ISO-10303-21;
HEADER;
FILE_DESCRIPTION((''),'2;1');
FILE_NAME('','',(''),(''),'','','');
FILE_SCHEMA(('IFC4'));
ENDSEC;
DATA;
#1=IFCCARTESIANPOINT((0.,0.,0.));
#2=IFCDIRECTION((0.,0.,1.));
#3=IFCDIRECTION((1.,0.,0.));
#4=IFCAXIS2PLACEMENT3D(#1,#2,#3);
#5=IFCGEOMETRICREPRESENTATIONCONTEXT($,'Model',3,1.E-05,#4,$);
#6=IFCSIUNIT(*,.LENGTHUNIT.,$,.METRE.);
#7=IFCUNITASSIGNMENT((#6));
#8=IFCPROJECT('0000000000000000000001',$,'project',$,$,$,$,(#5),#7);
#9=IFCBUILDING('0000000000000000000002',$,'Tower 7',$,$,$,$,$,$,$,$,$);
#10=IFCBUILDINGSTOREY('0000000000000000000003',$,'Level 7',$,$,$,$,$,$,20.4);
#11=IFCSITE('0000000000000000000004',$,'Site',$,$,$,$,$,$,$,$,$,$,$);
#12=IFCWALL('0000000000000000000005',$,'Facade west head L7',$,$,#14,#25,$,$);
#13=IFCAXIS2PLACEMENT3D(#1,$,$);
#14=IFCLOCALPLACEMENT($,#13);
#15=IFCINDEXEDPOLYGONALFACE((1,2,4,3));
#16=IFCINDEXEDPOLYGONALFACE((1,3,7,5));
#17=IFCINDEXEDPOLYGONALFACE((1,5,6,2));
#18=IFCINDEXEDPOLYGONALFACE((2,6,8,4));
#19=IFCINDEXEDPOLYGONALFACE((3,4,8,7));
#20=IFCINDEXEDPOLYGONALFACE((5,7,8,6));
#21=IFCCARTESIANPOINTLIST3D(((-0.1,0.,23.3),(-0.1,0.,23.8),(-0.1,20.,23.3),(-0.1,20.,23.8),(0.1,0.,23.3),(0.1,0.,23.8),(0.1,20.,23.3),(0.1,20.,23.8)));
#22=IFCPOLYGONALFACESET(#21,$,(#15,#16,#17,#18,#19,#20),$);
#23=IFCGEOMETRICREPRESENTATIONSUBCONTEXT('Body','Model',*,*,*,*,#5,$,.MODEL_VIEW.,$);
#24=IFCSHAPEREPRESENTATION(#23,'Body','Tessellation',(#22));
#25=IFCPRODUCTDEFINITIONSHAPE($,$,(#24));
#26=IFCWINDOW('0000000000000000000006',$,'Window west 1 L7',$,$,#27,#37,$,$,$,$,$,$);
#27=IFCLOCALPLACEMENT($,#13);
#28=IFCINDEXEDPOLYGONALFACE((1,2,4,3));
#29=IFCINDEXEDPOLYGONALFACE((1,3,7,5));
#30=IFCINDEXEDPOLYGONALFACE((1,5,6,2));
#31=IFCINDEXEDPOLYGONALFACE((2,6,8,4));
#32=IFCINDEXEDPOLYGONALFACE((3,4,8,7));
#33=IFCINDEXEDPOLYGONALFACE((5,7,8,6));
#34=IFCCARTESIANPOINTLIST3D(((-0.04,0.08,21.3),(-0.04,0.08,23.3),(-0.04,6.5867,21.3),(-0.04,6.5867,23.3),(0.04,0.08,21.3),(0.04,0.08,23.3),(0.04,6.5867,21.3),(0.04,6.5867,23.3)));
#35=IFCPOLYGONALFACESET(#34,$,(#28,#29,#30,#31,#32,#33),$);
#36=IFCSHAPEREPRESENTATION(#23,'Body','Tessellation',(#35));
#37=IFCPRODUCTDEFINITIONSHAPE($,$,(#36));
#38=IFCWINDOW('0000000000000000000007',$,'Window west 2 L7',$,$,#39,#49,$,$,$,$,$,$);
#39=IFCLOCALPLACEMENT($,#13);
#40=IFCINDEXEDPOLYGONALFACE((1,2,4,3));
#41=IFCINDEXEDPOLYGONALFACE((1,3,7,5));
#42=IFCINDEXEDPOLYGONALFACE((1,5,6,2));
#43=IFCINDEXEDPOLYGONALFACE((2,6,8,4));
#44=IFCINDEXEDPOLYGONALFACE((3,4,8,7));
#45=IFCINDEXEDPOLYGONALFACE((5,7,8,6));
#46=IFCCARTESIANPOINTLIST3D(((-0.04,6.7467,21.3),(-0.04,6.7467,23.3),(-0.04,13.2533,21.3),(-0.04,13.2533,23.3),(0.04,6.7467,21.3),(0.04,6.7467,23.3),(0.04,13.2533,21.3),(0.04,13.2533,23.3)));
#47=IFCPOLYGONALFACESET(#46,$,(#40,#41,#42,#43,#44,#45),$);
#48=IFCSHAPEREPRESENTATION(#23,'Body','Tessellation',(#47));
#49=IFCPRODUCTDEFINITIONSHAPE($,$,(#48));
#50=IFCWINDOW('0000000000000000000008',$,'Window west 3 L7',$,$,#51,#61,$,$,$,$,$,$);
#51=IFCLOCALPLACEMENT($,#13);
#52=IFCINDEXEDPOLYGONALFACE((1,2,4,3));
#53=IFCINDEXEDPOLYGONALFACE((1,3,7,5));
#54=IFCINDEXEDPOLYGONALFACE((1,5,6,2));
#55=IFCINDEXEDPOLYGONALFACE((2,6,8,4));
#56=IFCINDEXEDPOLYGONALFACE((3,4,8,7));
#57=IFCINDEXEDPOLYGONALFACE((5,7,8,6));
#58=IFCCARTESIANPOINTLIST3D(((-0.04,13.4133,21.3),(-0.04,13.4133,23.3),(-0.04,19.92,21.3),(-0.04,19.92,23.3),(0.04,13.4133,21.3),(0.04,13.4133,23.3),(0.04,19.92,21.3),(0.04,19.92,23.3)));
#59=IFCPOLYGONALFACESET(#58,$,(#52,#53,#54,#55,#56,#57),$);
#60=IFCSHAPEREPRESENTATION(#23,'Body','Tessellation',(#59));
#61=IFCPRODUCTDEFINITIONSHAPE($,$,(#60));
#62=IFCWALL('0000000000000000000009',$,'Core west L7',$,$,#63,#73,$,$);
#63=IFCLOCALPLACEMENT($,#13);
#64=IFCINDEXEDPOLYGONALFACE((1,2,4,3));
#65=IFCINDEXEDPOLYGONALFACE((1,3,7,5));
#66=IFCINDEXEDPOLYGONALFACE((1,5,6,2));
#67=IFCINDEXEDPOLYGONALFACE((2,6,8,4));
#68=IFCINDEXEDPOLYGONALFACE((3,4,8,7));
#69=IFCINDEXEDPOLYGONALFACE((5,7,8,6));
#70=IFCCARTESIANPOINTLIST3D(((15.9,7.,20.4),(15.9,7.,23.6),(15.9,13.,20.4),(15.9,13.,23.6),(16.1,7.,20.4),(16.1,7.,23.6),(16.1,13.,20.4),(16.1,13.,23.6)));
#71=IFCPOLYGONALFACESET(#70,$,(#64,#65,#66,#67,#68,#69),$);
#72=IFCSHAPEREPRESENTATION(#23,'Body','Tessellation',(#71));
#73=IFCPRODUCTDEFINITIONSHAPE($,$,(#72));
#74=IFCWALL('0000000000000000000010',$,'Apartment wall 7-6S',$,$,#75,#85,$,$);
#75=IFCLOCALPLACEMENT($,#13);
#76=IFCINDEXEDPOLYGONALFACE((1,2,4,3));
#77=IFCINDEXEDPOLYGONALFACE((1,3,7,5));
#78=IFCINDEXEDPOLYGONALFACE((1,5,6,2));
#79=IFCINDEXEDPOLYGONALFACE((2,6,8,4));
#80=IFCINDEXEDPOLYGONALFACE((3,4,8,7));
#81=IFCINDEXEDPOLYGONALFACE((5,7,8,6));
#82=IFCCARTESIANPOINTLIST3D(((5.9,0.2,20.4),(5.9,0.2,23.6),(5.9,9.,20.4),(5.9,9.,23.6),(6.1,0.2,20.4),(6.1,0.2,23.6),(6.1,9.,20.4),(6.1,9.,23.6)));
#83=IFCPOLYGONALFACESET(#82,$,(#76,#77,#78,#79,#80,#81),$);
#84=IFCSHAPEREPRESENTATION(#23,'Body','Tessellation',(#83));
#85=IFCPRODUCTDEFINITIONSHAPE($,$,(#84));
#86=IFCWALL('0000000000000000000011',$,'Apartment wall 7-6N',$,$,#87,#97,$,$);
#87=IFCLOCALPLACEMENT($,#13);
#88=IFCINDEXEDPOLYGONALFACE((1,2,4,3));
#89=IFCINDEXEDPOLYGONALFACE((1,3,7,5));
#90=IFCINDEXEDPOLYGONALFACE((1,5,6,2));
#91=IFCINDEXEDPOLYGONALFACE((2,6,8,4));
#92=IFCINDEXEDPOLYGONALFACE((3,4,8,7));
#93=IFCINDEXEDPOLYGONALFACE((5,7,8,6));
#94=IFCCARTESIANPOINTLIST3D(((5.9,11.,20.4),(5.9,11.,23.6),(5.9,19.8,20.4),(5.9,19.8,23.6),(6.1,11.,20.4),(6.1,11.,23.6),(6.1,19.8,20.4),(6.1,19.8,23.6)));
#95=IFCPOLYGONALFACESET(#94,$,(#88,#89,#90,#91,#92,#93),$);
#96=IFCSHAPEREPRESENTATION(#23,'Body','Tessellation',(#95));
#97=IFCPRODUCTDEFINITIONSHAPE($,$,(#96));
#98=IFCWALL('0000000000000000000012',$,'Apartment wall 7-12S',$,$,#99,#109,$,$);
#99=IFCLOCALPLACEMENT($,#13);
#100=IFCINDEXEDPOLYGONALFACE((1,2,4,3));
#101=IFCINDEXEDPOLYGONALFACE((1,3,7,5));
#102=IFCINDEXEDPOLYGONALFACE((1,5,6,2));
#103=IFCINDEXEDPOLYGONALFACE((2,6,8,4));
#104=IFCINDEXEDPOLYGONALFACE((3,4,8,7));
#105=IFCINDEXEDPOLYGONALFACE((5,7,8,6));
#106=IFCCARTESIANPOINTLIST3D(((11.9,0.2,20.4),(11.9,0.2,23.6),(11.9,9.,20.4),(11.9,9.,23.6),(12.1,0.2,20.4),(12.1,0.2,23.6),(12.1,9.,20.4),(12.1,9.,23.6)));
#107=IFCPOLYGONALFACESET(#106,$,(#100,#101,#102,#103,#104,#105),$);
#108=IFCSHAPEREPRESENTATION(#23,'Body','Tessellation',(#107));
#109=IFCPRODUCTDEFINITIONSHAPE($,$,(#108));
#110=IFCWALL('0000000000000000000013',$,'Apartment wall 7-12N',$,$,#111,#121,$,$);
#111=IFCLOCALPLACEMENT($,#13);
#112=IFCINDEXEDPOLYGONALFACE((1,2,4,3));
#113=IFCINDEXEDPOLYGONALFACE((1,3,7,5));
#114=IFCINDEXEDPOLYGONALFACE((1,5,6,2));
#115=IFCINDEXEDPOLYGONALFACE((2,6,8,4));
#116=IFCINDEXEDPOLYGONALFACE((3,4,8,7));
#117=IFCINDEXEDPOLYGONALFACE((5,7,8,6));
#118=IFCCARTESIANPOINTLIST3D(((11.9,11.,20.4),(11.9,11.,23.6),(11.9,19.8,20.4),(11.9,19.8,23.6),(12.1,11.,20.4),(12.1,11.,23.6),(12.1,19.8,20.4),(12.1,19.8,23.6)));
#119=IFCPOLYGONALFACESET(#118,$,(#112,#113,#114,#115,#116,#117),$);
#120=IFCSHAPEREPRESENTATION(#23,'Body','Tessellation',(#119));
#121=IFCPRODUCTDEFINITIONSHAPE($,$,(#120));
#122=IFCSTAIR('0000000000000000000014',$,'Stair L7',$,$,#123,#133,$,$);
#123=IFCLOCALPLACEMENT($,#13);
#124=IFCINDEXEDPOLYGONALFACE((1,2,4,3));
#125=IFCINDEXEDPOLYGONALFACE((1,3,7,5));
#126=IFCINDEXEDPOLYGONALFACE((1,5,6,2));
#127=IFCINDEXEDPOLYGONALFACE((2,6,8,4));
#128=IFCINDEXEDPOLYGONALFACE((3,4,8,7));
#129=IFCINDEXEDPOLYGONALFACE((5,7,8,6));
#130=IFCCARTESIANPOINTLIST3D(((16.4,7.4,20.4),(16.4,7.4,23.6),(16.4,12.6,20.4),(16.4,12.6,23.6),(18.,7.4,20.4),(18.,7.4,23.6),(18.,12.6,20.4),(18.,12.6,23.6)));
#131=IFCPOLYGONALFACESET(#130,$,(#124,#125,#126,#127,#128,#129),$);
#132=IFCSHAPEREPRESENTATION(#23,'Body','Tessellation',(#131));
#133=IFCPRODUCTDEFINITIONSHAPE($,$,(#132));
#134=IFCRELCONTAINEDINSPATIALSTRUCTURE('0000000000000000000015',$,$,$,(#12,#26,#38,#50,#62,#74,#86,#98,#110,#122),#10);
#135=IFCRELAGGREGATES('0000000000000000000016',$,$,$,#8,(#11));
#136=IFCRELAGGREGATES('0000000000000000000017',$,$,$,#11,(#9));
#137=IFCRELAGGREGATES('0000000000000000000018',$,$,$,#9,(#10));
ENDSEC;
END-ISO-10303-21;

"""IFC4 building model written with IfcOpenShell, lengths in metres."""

from ifc_helpers import new_model, si_unit, frame, origin, origin_with_axes, origin_2d, place, context, subcontext, project, spatial, rectangle, extrude, element, save


model = new_model("IFC4")

# Units and contexts
model_context = context("Model", 3, precision=1e-05, world=origin_with_axes())
body_context = subcontext(model_context, "Body", "Model", "MODEL_VIEW")
ifc_project = project(units=[si_unit("LENGTHUNIT", "METRE")], contexts=[model_context])

# Site, building, storey
site = spatial("IfcSite", under=ifc_project, Name="Site")
building = spatial("IfcBuilding", under=site, Name="Tower 7")
storey = spatial("IfcBuildingStorey", under=building, Name="Level 7", Elevation=20.4)

# Wall
wall_1_placement = place(None, frame((0.0, 10.0, 23.3), z_axis=(0.0, 0.0, 1.0), x_axis=(1.0, 0.0, 0.0)))
element("IfcWall", 1, at=wall_1_placement, inside=storey, Name="Facade west head L7", context=body_context, shape_type="SweptSolid", body=[
    extrude(rectangle(XDim=0.2, YDim=20.0, at=origin_2d()), origin(), (0.0, 0.0, 1.0), 0.5),
])

# Windows
for number, where, z_axis, x_axis, name in (
    (2, (0.0, 3.3333, 21.3), (0.0, 0.0, 1.0), (1.0, 0.0, 0.0), "Window west 1 L7"),
    (3, (0.0, 10.0, 21.3), (0.0, 0.0, 1.0), (1.0, 0.0, 0.0), "Window west 2 L7"),
):
    element("IfcWindow", number, at=place(None, frame(where, z_axis=z_axis, x_axis=x_axis)), inside=storey, Name=name, context=body_context, shape_type="SweptSolid", body=[
        extrude(rectangle(XDim=0.08, YDim=6.5067, at=origin_2d()), origin(), (0.0, 0.0, 1.0), 2.0),
    ])
window_1_placement = place(None, frame((0.0, 16.6667, 21.3), z_axis=(0.0, 0.0, 1.0), x_axis=(1.0, 0.0, 0.0)))
element("IfcWindow", 4, at=window_1_placement, inside=storey, Name="Window west 3 L7", context=body_context, shape_type="SweptSolid", body=[
    extrude(rectangle(XDim=0.08, YDim=6.5067, at=origin_2d()), origin(), (0.0, 0.0, 1.0), 2.0),
])

# Walls
wall_2_placement = place(None, frame((16.0, 10.0, 20.4), z_axis=(0.0, 0.0, 1.0), x_axis=(1.0, 0.0, 0.0)))
element("IfcWall", 5, at=wall_2_placement, inside=storey, Name="Core west L7", context=body_context, shape_type="SweptSolid", body=[
    extrude(rectangle(XDim=0.2, YDim=6.0, at=origin_2d()), origin(), (0.0, 0.0, 1.0), 3.2),
])
for number, where, z_axis, x_axis, name in (
    (6, (6.0, 4.6, 20.4), (0.0, 0.0, 1.0), (1.0, 0.0, 0.0), "Apartment wall 7-6S"),
    (7, (6.0, 15.4, 20.4), (0.0, 0.0, 1.0), (1.0, 0.0, 0.0), "Apartment wall 7-6N"),
    (8, (12.0, 4.6, 20.4), (0.0, 0.0, 1.0), (1.0, 0.0, 0.0), "Apartment wall 7-12S"),
    (9, (12.0, 15.4, 20.4), (0.0, 0.0, 1.0), (1.0, 0.0, 0.0), "Apartment wall 7-12N"),
):
    element("IfcWall", number, at=place(None, frame(where, z_axis=z_axis, x_axis=x_axis)), inside=storey, Name=name, context=body_context, shape_type="SweptSolid", body=[
        extrude(rectangle(XDim=0.2, YDim=8.8, at=origin_2d()), origin(), (0.0, 0.0, 1.0), 3.2),
    ])

# Stair
stair_placement = place(None, frame((17.2, 10.0, 20.4), z_axis=(0.0, 0.0, 1.0), x_axis=(1.0, 0.0, 0.0)))
element("IfcStair", 10, at=stair_placement, inside=storey, Name="Stair L7", context=body_context, shape_type="SweptSolid", body=[
    extrude(rectangle(XDim=1.6, YDim=5.2, at=origin_2d()), origin(), (0.0, 0.0, 1.0), 3.2),
])

save(model, "model.ifc")
